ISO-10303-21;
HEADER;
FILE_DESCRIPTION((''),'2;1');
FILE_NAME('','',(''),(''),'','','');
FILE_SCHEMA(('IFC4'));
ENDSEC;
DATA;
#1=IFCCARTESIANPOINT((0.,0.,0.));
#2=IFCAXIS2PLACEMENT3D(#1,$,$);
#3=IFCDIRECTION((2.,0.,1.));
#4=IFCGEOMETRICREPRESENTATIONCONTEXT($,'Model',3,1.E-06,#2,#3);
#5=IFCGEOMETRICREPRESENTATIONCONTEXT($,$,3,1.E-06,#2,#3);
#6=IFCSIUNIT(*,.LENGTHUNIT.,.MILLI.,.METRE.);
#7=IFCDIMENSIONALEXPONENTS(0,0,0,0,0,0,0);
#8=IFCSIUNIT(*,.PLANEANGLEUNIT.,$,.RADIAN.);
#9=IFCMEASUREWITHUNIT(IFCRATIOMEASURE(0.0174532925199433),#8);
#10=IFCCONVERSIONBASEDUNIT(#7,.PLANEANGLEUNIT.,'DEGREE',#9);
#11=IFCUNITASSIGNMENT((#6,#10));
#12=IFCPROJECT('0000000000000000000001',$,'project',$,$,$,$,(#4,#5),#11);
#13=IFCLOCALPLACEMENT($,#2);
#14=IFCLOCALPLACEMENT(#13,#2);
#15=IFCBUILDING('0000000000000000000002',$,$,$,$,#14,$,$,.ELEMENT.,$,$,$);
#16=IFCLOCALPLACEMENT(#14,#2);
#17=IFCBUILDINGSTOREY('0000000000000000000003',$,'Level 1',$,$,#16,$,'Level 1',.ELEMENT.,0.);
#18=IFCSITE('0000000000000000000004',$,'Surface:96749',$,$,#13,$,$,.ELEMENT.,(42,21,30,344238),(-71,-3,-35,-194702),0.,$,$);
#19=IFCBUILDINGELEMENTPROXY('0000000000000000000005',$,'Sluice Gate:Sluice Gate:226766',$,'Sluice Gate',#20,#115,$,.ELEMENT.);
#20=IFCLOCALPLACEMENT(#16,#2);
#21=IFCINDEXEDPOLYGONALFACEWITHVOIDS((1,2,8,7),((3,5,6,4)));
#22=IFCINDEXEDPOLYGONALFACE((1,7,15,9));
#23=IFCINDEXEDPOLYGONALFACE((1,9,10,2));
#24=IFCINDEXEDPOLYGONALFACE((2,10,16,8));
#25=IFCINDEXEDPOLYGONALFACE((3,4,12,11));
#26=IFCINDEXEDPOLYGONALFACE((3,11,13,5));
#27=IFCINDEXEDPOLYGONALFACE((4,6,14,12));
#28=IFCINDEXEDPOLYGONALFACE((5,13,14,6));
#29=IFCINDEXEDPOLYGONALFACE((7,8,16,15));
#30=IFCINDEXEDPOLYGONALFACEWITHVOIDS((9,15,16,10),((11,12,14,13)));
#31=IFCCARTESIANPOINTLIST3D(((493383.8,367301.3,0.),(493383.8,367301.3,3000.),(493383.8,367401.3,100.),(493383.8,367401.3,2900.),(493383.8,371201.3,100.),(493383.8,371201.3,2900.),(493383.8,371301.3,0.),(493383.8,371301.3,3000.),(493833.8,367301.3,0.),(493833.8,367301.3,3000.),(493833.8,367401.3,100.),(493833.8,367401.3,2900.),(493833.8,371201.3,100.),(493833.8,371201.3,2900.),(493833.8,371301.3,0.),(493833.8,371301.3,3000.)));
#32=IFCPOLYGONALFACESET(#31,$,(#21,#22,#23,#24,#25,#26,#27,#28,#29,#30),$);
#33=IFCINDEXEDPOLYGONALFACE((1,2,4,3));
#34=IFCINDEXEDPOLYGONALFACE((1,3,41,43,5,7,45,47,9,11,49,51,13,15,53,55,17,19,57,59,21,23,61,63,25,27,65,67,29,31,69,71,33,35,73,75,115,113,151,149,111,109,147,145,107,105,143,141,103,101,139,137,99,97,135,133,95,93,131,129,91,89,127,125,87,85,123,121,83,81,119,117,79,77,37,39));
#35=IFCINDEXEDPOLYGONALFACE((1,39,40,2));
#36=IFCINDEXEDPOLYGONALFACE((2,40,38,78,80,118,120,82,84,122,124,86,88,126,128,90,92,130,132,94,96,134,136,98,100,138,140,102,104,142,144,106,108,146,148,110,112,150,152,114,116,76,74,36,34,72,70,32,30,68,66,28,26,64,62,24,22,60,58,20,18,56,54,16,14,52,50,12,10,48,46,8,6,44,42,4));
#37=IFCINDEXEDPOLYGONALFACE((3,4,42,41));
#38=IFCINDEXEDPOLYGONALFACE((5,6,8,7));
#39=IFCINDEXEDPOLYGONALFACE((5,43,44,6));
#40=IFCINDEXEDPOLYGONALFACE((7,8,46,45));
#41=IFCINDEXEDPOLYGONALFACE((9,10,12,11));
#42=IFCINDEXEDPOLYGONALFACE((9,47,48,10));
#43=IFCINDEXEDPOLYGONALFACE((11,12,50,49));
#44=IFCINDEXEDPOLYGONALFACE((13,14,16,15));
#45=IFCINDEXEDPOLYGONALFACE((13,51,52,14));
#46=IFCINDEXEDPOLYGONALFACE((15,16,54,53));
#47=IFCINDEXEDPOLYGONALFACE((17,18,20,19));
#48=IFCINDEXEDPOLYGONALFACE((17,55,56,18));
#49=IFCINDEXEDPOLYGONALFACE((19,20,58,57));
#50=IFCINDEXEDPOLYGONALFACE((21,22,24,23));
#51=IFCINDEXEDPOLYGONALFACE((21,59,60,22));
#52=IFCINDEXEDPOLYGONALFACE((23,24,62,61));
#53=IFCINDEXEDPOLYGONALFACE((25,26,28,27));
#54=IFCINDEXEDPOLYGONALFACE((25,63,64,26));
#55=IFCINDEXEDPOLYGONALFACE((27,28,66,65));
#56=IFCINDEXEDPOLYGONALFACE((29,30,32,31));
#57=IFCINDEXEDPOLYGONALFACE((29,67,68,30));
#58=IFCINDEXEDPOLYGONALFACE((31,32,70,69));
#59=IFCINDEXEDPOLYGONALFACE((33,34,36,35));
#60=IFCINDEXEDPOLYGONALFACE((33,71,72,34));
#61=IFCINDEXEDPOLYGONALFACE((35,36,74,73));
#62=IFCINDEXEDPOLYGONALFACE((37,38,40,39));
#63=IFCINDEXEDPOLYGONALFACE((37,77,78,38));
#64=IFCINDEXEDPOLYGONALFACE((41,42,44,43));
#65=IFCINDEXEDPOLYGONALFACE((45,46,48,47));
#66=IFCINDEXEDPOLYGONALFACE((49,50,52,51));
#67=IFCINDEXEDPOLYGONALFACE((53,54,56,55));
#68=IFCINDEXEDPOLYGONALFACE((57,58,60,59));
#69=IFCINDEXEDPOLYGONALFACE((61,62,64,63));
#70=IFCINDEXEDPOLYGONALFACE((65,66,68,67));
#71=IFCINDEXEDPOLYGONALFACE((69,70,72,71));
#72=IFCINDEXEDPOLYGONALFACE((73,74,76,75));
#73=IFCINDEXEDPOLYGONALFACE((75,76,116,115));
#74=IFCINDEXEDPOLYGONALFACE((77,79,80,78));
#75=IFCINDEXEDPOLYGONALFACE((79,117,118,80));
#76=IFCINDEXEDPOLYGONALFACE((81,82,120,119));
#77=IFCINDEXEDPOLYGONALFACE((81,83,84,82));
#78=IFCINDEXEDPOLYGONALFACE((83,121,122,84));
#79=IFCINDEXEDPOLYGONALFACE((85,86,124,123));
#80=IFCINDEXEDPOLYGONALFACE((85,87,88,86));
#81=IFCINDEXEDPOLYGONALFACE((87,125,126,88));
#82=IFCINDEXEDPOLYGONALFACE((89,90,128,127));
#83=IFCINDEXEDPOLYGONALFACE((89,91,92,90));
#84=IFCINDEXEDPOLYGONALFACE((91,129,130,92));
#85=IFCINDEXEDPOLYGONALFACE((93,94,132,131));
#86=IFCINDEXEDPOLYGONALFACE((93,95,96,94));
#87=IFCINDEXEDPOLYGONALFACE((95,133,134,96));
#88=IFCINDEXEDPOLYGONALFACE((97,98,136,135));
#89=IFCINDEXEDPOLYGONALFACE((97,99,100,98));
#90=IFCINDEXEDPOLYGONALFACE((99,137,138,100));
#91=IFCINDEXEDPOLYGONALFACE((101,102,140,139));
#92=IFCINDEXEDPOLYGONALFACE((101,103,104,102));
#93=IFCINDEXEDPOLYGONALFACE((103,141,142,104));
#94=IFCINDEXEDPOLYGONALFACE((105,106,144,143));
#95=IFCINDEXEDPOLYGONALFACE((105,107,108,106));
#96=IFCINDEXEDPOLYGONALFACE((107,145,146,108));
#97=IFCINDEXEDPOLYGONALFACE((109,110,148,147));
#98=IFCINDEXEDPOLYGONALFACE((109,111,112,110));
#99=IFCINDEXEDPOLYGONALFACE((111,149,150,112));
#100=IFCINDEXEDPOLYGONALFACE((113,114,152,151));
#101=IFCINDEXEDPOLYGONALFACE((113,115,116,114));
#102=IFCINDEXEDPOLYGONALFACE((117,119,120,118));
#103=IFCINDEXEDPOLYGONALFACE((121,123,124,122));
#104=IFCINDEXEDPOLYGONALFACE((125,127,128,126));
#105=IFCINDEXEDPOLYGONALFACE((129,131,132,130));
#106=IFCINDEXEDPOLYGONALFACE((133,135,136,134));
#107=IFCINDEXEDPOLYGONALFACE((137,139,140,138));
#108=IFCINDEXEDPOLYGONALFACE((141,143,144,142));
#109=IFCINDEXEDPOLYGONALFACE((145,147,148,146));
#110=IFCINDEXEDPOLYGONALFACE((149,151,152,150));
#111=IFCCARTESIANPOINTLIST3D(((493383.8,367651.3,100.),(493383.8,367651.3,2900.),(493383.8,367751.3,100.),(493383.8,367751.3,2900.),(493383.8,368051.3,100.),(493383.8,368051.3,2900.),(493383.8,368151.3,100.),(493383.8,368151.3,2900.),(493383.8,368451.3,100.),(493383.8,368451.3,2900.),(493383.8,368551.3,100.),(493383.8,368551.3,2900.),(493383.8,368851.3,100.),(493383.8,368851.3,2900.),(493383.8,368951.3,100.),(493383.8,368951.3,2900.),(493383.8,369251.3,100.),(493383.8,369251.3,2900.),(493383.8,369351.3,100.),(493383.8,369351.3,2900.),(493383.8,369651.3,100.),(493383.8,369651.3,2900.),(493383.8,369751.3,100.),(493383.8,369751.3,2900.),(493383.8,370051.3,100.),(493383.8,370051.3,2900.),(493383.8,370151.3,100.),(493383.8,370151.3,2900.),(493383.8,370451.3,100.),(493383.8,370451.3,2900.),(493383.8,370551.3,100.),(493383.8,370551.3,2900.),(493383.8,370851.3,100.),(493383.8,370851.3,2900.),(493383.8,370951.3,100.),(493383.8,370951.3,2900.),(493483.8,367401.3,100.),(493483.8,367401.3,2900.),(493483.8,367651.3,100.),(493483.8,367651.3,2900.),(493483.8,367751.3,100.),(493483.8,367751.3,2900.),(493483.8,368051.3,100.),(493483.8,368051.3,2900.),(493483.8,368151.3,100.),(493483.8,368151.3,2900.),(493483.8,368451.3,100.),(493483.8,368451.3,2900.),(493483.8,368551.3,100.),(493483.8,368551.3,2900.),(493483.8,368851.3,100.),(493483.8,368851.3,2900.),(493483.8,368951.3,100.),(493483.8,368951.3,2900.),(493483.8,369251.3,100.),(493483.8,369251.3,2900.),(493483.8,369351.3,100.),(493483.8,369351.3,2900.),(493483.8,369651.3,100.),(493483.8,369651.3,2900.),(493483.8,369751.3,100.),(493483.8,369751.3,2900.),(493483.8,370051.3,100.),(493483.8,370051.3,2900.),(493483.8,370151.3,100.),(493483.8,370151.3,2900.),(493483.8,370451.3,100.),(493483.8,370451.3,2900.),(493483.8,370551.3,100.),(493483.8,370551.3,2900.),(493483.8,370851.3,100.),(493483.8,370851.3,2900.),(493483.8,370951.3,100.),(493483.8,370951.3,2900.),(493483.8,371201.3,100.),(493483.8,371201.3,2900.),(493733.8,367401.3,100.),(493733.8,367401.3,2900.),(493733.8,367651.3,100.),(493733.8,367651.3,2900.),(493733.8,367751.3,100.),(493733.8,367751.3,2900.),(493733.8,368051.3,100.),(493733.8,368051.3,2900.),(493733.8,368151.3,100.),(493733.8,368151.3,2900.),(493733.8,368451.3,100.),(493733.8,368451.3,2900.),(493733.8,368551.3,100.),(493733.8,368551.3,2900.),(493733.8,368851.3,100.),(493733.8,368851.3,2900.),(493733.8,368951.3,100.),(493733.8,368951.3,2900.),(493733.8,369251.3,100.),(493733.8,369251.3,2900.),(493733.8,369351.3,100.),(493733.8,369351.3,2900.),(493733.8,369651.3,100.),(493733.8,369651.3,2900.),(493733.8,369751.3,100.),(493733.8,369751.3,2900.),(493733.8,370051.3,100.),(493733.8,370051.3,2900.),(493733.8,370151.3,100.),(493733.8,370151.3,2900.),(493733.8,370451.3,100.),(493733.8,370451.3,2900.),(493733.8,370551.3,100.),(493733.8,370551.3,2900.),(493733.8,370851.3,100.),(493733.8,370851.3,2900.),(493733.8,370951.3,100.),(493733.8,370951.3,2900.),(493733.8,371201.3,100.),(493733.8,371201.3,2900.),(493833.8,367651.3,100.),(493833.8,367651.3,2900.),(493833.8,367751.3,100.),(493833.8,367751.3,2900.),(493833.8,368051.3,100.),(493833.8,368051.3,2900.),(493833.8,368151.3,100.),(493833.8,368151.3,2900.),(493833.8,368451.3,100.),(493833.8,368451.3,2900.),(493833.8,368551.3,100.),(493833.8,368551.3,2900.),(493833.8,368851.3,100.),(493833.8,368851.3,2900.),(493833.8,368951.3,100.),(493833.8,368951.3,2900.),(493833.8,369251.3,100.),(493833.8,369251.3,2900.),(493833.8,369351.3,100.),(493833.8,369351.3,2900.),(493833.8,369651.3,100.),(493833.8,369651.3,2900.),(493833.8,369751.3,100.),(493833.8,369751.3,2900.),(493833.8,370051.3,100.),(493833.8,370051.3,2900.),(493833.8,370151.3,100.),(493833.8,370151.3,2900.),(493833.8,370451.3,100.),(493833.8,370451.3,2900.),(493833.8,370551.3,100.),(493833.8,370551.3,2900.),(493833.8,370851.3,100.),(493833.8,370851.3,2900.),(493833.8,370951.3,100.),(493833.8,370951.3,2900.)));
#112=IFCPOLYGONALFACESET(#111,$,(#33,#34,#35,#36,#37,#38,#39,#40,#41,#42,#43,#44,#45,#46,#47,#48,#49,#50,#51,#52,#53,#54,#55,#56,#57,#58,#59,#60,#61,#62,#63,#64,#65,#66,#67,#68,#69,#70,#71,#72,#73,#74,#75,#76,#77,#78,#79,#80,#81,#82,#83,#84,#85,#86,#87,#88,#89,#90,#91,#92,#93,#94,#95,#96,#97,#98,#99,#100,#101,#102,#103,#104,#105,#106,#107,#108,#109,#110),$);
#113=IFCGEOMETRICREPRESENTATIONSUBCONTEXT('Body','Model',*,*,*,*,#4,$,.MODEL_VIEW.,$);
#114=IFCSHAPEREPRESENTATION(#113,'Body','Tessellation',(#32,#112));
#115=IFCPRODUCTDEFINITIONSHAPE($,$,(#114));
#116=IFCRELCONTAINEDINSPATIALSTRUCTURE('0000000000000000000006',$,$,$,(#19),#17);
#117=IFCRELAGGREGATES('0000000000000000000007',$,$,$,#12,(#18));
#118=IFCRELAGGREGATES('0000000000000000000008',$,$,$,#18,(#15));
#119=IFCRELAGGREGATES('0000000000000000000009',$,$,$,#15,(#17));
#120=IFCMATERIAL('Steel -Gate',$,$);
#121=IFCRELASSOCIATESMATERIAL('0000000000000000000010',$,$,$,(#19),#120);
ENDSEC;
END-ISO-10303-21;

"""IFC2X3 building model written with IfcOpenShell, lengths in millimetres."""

from ifc_helpers import new_model, entity, si_unit, converted_unit, direction, frame, origin, place, context, subcontext, project, spatial, polyline, outline, extrude, source, transform, mapped, material, element, save


model = new_model("IFC2X3")

# Units and contexts
model_context = context("Model", 3, precision=1e-06, world=origin(), true_north=direction((2.0, 0.0, 1.0)))
context_of_model = context(None, 3, precision=1e-06, world=origin(), true_north=direction((2.0, 0.0, 1.0)))
body_context = subcontext(model_context, "Body", "Model", "MODEL_VIEW")
ifc_project = project(units=[si_unit("LENGTHUNIT", "METRE", prefix="MILLI"), converted_unit("PLANEANGLEUNIT", "DEGREE", entity("IfcRatioMeasure", 0.0174532925199433), si_unit("PLANEANGLEUNIT", "RADIAN"), dimensions=[0, 0, 0, 0, 0, 0, 0])], contexts=[model_context, context_of_model])

# Site, building, storey
site_placement = place(None, origin())
site = spatial("IfcSite", under=ifc_project, at=site_placement, Name="Surface:96749", CompositionType="ELEMENT", RefLatitude=(42, 21, 30, 344238), RefLongitude=(-71, -3, -35, -194702), RefElevation=0.0)
building_placement = place(site_placement, origin())
building = spatial("IfcBuilding", under=site, at=building_placement, CompositionType="ELEMENT")
storey_placement = place(building_placement, origin())
storey = spatial("IfcBuildingStorey", under=building, at=storey_placement, Name="Level 1", LongName="Level 1", CompositionType="ELEMENT", Elevation=0.0)

# Building element proxy
ifc_material = material(Name="Steel -Gate")
shared_shape_1 = source(origin(), body_context, "Body", "SweptSolid", [
    extrude(outline(polyline([(-2000.0, -1500.0), (2000.0, -1500.0), (2000.0, 1500.0), (-2000.0, 1500.0), (-2000.0, -1500.0)]), holes=[polyline([(-1900.0, 1400.0), (1900.0, 1400.0), (1900.0, -1400.0), (-1900.0, -1400.0), (-1900.0, 1400.0)])]), frame((0.0, -225.0, 1500.0), z_axis=(0.0, 1.0, 0.0), x_axis=(-1.0, 0.0, 0.0)), (0.0, 0.0, 1.0), 450.0),
    extrude(outline(polyline([(125.0, -1650.0), (225.0, -1650.0), (225.0, -1550.0), (125.0, -1550.0), (125.0, -1250.0), (225.0, -1250.0), (225.0, -1150.0), (125.0, -1150.0), (125.0, -850.0), (225.0, -850.0), (225.0, -750.0), (125.0, -750.0), (125.0, -450.0), (225.0, -450.0), (225.0, -350.0), (125.0, -350.0), (125.0, -50.0), (225.0, -50.0), (225.0, 50.0), (125.0, 50.0), (125.0, 350.0), (225.0, 350.0), (225.0, 450.0), (125.0, 450.0), (125.0, 750.0), (225.0, 750.0), (225.0, 850.0), (125.0, 850.0), (125.0, 1150.0), (225.0, 1150.0), (225.0, 1250.0), (125.0, 1250.0), (125.0, 1550.0), (225.0, 1550.0), (225.0, 1650.0), (125.0, 1650.0), (125.0, 1900.0), (-125.0, 1900.0), (-125.0, 1650.0), (-225.0, 1650.0), (-225.0, 1550.0), (-125.0, 1550.0), (-125.0, 1250.0), (-225.0, 1250.0), (-225.0, 1150.0), (-125.0, 1150.0), (-125.0, 850.0), (-225.0, 850.0), (-225.0, 750.0), (-125.0, 750.0), (-125.0, 450.0), (-225.0, 450.0), (-225.0, 350.0), (-125.0, 350.0), (-125.0, 50.0), (-225.0, 50.0), (-225.0, -50.0), (-125.0, -50.0), (-125.0, -350.0), (-225.0, -350.0), (-225.0, -450.0), (-125.0, -450.0), (-125.0, -750.0), (-225.0, -750.0), (-225.0, -850.0), (-125.0, -850.0), (-125.0, -1150.0), (-225.0, -1150.0), (-225.0, -1250.0), (-125.0, -1250.0), (-125.0, -1550.0), (-225.0, -1550.0), (-225.0, -1650.0), (-125.0, -1650.0), (-125.0, -1900.0), (125.0, -1900.0), (125.0, -1650.0)])), frame((0.0, 0.0, 100.0), z_axis=(0.0, 0.0, 1.0), x_axis=(0.0, -1.0, 0.0)), (0.0, 0.0, 1.0), 2800.0),
])
for number, where, z_axis, x_axis, name in (
    (1, (493608.8, 369301.3, 0.0), (0.0, 0.0, 1.0), (0.0, 1.0, 0.0), "Sluice Gate:Sluice Gate:226766"),
):
    element("IfcBuildingElementProxy", number, at=place(storey_placement, frame(where, z_axis=z_axis, x_axis=x_axis)), inside=storey, material=ifc_material, Name=name, ObjectType="Sluice Gate", CompositionType="ELEMENT", context=body_context, shape_type="MappedRepresentation", body=[
        mapped(shared_shape_1, transform((0.0, 0.0, 0.0), scale=1.0)),
    ])

save(model, "model.ifc")
